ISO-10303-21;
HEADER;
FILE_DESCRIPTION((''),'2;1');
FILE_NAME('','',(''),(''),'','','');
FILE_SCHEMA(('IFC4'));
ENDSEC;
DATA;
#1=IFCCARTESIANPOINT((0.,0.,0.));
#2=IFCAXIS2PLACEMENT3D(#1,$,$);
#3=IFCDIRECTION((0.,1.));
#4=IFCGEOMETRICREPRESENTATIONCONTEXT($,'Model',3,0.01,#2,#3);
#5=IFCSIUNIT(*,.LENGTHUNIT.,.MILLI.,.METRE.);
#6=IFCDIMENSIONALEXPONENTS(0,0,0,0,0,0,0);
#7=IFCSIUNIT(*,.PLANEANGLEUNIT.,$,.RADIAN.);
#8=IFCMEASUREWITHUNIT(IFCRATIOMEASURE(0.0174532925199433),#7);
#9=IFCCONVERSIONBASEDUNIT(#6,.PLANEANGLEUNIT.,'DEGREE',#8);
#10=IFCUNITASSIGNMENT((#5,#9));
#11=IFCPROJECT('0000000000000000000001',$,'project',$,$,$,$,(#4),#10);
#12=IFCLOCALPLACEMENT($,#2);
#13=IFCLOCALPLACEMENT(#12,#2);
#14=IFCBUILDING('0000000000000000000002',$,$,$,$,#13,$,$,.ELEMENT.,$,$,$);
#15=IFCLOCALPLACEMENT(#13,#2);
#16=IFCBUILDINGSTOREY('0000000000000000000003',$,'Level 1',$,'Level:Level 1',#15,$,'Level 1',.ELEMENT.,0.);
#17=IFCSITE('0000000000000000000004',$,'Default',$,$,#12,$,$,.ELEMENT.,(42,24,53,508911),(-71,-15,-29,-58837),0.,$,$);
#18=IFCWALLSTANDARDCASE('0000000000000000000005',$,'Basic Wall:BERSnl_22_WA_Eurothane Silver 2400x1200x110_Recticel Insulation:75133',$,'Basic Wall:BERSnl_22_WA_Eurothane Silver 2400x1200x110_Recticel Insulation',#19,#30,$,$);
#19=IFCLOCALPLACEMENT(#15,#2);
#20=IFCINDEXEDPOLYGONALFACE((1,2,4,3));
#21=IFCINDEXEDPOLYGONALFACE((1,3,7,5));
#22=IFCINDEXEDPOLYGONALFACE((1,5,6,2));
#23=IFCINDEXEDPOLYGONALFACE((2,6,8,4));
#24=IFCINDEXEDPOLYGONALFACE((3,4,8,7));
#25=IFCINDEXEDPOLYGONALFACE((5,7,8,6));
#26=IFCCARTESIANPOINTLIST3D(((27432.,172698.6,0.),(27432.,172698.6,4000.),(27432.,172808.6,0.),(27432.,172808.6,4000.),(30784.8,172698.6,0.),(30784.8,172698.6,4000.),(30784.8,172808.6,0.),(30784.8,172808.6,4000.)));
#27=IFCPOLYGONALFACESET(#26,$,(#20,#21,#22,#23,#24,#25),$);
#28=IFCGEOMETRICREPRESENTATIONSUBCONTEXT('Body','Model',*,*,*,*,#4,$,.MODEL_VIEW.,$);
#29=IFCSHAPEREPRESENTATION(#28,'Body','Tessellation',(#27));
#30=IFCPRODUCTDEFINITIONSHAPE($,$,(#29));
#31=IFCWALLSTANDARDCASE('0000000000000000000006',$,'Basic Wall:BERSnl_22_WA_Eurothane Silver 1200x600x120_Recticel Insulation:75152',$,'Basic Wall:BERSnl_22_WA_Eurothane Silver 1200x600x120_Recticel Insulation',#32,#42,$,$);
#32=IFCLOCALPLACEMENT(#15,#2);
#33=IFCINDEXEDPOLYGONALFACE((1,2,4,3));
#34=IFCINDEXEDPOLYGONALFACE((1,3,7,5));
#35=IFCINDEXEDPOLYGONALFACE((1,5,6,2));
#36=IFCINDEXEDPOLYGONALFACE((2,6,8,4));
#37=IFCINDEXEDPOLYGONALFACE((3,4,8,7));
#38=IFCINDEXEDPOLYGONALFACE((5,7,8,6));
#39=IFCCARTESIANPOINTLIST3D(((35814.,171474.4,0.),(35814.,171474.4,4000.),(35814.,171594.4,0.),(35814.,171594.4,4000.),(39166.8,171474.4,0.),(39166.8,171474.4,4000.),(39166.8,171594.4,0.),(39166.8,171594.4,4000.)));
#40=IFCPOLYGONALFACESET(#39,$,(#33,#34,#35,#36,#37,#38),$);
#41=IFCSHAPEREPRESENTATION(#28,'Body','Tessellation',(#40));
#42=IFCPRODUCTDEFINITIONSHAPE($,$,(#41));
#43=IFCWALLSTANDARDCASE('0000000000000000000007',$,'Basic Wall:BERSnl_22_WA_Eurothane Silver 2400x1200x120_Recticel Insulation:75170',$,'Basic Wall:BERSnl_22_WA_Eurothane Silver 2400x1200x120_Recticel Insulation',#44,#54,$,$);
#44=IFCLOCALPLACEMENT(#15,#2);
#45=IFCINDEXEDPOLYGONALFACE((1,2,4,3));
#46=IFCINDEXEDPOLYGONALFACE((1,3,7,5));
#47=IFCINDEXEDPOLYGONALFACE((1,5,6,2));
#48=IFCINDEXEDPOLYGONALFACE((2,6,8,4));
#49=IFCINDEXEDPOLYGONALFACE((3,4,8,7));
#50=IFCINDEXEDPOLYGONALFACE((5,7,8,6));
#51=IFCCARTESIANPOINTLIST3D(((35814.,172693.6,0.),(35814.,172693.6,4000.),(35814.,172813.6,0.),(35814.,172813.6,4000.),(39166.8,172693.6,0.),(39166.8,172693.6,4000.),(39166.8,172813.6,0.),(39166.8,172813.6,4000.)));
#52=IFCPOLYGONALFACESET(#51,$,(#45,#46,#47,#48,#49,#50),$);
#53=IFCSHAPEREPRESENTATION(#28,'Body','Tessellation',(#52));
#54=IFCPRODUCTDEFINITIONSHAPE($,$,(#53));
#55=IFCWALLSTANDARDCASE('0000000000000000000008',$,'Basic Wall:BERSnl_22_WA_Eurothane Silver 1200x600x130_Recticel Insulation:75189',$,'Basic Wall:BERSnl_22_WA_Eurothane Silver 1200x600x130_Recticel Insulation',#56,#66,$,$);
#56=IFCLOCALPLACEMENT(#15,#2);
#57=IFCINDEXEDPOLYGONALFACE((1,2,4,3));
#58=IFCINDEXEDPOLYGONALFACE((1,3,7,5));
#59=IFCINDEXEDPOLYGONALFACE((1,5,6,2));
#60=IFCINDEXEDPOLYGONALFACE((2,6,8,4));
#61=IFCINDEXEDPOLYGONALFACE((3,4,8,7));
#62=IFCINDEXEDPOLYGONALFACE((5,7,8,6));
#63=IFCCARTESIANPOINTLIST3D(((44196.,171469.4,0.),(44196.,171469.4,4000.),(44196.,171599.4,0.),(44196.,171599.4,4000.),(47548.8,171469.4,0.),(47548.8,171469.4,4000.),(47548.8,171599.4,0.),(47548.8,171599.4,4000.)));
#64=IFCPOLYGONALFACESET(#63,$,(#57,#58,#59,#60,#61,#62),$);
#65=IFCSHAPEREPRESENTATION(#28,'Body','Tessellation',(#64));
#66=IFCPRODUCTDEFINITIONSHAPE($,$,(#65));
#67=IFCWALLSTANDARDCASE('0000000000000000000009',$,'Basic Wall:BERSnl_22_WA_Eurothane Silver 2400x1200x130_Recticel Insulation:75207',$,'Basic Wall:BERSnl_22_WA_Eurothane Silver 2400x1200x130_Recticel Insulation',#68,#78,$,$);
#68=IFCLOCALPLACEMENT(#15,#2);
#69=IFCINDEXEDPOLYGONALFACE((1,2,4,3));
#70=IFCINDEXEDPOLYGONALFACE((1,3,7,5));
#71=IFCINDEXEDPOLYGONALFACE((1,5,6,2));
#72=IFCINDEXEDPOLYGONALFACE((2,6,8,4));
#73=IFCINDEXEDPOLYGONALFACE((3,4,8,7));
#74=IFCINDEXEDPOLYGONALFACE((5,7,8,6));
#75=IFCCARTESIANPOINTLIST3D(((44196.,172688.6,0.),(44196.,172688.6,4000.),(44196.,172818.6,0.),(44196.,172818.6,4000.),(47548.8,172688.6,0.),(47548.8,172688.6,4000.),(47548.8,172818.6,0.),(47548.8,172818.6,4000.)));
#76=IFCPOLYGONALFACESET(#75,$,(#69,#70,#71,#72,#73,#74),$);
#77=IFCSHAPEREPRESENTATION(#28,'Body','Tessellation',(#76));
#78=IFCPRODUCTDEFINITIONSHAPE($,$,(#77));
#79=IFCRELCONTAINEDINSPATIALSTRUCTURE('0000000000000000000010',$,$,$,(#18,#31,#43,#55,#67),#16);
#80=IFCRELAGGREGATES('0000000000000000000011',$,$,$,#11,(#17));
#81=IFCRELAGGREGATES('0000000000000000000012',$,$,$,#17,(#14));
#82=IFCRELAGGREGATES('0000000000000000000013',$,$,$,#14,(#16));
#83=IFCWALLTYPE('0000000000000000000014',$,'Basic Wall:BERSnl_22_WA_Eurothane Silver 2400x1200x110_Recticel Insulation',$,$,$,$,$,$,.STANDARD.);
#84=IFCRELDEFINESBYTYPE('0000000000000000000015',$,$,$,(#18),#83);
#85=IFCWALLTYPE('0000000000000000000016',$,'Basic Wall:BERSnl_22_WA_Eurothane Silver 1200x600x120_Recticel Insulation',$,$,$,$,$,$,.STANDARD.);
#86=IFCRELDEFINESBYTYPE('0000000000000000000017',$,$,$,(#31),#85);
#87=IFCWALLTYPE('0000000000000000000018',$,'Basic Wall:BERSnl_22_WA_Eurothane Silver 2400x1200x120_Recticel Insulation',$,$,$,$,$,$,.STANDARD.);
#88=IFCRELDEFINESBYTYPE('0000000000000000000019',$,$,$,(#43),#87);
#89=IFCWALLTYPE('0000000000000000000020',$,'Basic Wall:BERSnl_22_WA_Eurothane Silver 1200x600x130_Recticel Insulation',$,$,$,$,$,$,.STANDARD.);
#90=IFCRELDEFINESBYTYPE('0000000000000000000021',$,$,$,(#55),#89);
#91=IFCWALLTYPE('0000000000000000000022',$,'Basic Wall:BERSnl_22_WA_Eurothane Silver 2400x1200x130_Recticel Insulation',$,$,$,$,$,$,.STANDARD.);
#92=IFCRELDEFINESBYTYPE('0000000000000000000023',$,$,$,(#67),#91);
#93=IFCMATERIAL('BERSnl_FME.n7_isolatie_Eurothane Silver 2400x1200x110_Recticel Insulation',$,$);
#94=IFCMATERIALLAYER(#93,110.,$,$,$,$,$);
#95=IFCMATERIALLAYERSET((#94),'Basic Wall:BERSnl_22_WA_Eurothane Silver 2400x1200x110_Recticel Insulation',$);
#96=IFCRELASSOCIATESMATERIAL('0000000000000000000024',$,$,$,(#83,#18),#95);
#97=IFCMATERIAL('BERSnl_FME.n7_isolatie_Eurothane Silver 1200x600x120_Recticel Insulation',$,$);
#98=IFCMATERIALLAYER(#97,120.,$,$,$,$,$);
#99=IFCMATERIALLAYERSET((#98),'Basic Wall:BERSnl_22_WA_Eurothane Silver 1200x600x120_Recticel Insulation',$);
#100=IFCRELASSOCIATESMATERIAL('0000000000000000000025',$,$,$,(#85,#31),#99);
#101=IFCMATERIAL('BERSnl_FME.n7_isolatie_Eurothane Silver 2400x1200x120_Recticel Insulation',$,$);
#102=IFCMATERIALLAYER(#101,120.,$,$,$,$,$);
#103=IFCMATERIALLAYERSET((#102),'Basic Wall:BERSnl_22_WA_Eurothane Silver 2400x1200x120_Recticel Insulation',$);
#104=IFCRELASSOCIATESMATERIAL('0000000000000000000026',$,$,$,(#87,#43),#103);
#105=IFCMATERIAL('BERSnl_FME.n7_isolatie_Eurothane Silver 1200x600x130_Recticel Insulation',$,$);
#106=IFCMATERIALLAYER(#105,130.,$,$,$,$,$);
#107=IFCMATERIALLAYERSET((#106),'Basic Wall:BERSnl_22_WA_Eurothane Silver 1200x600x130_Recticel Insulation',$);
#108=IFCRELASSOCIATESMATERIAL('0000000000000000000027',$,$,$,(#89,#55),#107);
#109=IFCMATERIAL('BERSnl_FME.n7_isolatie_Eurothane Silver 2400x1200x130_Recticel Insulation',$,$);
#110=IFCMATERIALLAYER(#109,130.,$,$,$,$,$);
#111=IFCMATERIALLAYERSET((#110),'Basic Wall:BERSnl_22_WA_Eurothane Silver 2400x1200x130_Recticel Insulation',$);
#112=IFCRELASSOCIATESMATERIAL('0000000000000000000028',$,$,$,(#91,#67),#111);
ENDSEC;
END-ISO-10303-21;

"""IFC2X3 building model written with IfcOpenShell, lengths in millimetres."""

from ifc_helpers import new_model, entity, si_unit, converted_unit, direction, frame, frame_2d, origin, place, context, subcontext, project, spatial, rectangle, extrude, material, layer, layer_set, layer_usage, type_object, element, save


model = new_model("IFC2X3")

# Units and contexts
model_context = context("Model", 3, precision=0.01, world=origin(), true_north=direction((0.0, 1.0)))
body_context = subcontext(model_context, "Body", "Model", "MODEL_VIEW")
ifc_project = project(units=[si_unit("LENGTHUNIT", "METRE", prefix="MILLI"), converted_unit("PLANEANGLEUNIT", "DEGREE", entity("IfcRatioMeasure", 0.0174532925199433), si_unit("PLANEANGLEUNIT", "RADIAN"), dimensions=[0, 0, 0, 0, 0, 0, 0])], contexts=[model_context])

# Site, building, storey
site_placement = place(None, origin())
site = spatial("IfcSite", under=ifc_project, at=site_placement, Name="Default", CompositionType="ELEMENT", RefLatitude=(42, 24, 53, 508911), RefLongitude=(-71, -15, -29, -58837), RefElevation=0.0)
building_placement = place(site_placement, origin())
building = spatial("IfcBuilding", under=site, at=building_placement, CompositionType="ELEMENT")
storey_placement = place(building_placement, origin())
storey = spatial("IfcBuildingStorey", under=building, at=storey_placement, Name="Level 1", ObjectType="Level:Level 1", LongName="Level 1", CompositionType="ELEMENT", Elevation=0.0)

# Shared definitions
ifc_material_1 = material(Name="BERSnl_FME.n7_isolatie_Eurothane Silver 2400x1200x110_Recticel Insulation")
ifc_material_2 = material(Name="BERSnl_FME.n7_isolatie_Eurothane Silver 1200x600x120_Recticel Insulation")
ifc_material_3 = material(Name="BERSnl_FME.n7_isolatie_Eurothane Silver 2400x1200x120_Recticel Insulation")
ifc_material_4 = material(Name="BERSnl_FME.n7_isolatie_Eurothane Silver 1200x600x130_Recticel Insulation")
ifc_material_5 = material(Name="BERSnl_FME.n7_isolatie_Eurothane Silver 2400x1200x130_Recticel Insulation")

# Walls
ifc_layer_1 = layer(ifc_material_1, 110.0)
ifc_layer_set_1 = layer_set([ifc_layer_1], Name="Basic Wall:BERSnl_22_WA_Eurothane Silver 2400x1200x110_Recticel Insulation")
ifc_layer_usage_1 = layer_usage(ifc_layer_set_1, "AXIS2", "NEGATIVE", 55.0)
wall_type_1 = type_object("IfcWallType", Name="Basic Wall:BERSnl_22_WA_Eurothane Silver 2400x1200x110_Recticel Insulation", PredefinedType="STANDARD", material=ifc_layer_set_1)
wall_1_placement = place(storey_placement, frame((27432.0, 172753.6, 0.0)))
element("IfcWallStandardCase", 1, at=wall_1_placement, inside=storey, type_object=wall_type_1, material=ifc_layer_usage_1, Name="Basic Wall:BERSnl_22_WA_Eurothane Silver 2400x1200x110_Recticel Insulation:75133", ObjectType="Basic Wall:BERSnl_22_WA_Eurothane Silver 2400x1200x110_Recticel Insulation", context=body_context, shape_type="SweptSolid", body=[
    extrude(rectangle(XDim=3352.8, YDim=110.0, at=frame_2d((1676.4, 0.0), x_axis=(-1.0, 0.0))), origin(), (0.0, 0.0, 1.0), 4000.0),
])
ifc_layer_2 = layer(ifc_material_2, 120.0)
ifc_layer_set_2 = layer_set([ifc_layer_2], Name="Basic Wall:BERSnl_22_WA_Eurothane Silver 1200x600x120_Recticel Insulation")
ifc_layer_usage_2 = layer_usage(ifc_layer_set_2, "AXIS2", "NEGATIVE", 60.0)
wall_type_2 = type_object("IfcWallType", Name="Basic Wall:BERSnl_22_WA_Eurothane Silver 1200x600x120_Recticel Insulation", PredefinedType="STANDARD", material=ifc_layer_set_2)
wall_2_placement = place(storey_placement, frame((35814.0, 171534.4, 0.0)))
element("IfcWallStandardCase", 2, at=wall_2_placement, inside=storey, type_object=wall_type_2, material=ifc_layer_usage_2, Name="Basic Wall:BERSnl_22_WA_Eurothane Silver 1200x600x120_Recticel Insulation:75152", ObjectType="Basic Wall:BERSnl_22_WA_Eurothane Silver 1200x600x120_Recticel Insulation", context=body_context, shape_type="SweptSolid", body=[
    extrude(rectangle(XDim=3352.8, YDim=120.0, at=frame_2d((1676.4, 0.0), x_axis=(-1.0, 0.0))), origin(), (0.0, 0.0, 1.0), 4000.0),
])
ifc_layer_3 = layer(ifc_material_3, 120.0)
ifc_layer_set_3 = layer_set([ifc_layer_3], Name="Basic Wall:BERSnl_22_WA_Eurothane Silver 2400x1200x120_Recticel Insulation")
ifc_layer_usage_3 = layer_usage(ifc_layer_set_3, "AXIS2", "NEGATIVE", 60.0)
wall_type_3 = type_object("IfcWallType", Name="Basic Wall:BERSnl_22_WA_Eurothane Silver 2400x1200x120_Recticel Insulation", PredefinedType="STANDARD", material=ifc_layer_set_3)
wall_3_placement = place(storey_placement, frame((35814.0, 172753.6, 0.0)))
element("IfcWallStandardCase", 3, at=wall_3_placement, inside=storey, type_object=wall_type_3, material=ifc_layer_usage_3, Name="Basic Wall:BERSnl_22_WA_Eurothane Silver 2400x1200x120_Recticel Insulation:75170", ObjectType="Basic Wall:BERSnl_22_WA_Eurothane Silver 2400x1200x120_Recticel Insulation", context=body_context, shape_type="SweptSolid", body=[
    extrude(rectangle(XDim=3352.8, YDim=120.0, at=frame_2d((1676.4, 0.0), x_axis=(-1.0, 0.0))), origin(), (0.0, 0.0, 1.0), 4000.0),
])
ifc_layer_4 = layer(ifc_material_4, 130.0)
ifc_layer_set_4 = layer_set([ifc_layer_4], Name="Basic Wall:BERSnl_22_WA_Eurothane Silver 1200x600x130_Recticel Insulation")
ifc_layer_usage_4 = layer_usage(ifc_layer_set_4, "AXIS2", "NEGATIVE", 65.0)
wall_type_4 = type_object("IfcWallType", Name="Basic Wall:BERSnl_22_WA_Eurothane Silver 1200x600x130_Recticel Insulation", PredefinedType="STANDARD", material=ifc_layer_set_4)
wall_4_placement = place(storey_placement, frame((44196.0, 171534.4, 0.0)))
element("IfcWallStandardCase", 4, at=wall_4_placement, inside=storey, type_object=wall_type_4, material=ifc_layer_usage_4, Name="Basic Wall:BERSnl_22_WA_Eurothane Silver 1200x600x130_Recticel Insulation:75189", ObjectType="Basic Wall:BERSnl_22_WA_Eurothane Silver 1200x600x130_Recticel Insulation", context=body_context, shape_type="SweptSolid", body=[
    extrude(rectangle(XDim=3352.8, YDim=130.0, at=frame_2d((1676.4, 0.0), x_axis=(-1.0, 0.0))), origin(), (0.0, 0.0, 1.0), 4000.0),
])
ifc_layer_5 = layer(ifc_material_5, 130.0)
ifc_layer_set_5 = layer_set([ifc_layer_5], Name="Basic Wall:BERSnl_22_WA_Eurothane Silver 2400x1200x130_Recticel Insulation")
ifc_layer_usage_5 = layer_usage(ifc_layer_set_5, "AXIS2", "NEGATIVE", 65.0)
wall_type_5 = type_object("IfcWallType", Name="Basic Wall:BERSnl_22_WA_Eurothane Silver 2400x1200x130_Recticel Insulation", PredefinedType="STANDARD", material=ifc_layer_set_5)
wall_5_placement = place(storey_placement, frame((44196.0, 172753.6, 0.0)))
element("IfcWallStandardCase", 5, at=wall_5_placement, inside=storey, type_object=wall_type_5, material=ifc_layer_usage_5, Name="Basic Wall:BERSnl_22_WA_Eurothane Silver 2400x1200x130_Recticel Insulation:75207", ObjectType="Basic Wall:BERSnl_22_WA_Eurothane Silver 2400x1200x130_Recticel Insulation", context=body_context, shape_type="SweptSolid", body=[
    extrude(rectangle(XDim=3352.8, YDim=130.0, at=frame_2d((1676.4, 0.0), x_axis=(-1.0, 0.0))), origin(), (0.0, 0.0, 1.0), 4000.0),
])

save(model, "model.ifc")
